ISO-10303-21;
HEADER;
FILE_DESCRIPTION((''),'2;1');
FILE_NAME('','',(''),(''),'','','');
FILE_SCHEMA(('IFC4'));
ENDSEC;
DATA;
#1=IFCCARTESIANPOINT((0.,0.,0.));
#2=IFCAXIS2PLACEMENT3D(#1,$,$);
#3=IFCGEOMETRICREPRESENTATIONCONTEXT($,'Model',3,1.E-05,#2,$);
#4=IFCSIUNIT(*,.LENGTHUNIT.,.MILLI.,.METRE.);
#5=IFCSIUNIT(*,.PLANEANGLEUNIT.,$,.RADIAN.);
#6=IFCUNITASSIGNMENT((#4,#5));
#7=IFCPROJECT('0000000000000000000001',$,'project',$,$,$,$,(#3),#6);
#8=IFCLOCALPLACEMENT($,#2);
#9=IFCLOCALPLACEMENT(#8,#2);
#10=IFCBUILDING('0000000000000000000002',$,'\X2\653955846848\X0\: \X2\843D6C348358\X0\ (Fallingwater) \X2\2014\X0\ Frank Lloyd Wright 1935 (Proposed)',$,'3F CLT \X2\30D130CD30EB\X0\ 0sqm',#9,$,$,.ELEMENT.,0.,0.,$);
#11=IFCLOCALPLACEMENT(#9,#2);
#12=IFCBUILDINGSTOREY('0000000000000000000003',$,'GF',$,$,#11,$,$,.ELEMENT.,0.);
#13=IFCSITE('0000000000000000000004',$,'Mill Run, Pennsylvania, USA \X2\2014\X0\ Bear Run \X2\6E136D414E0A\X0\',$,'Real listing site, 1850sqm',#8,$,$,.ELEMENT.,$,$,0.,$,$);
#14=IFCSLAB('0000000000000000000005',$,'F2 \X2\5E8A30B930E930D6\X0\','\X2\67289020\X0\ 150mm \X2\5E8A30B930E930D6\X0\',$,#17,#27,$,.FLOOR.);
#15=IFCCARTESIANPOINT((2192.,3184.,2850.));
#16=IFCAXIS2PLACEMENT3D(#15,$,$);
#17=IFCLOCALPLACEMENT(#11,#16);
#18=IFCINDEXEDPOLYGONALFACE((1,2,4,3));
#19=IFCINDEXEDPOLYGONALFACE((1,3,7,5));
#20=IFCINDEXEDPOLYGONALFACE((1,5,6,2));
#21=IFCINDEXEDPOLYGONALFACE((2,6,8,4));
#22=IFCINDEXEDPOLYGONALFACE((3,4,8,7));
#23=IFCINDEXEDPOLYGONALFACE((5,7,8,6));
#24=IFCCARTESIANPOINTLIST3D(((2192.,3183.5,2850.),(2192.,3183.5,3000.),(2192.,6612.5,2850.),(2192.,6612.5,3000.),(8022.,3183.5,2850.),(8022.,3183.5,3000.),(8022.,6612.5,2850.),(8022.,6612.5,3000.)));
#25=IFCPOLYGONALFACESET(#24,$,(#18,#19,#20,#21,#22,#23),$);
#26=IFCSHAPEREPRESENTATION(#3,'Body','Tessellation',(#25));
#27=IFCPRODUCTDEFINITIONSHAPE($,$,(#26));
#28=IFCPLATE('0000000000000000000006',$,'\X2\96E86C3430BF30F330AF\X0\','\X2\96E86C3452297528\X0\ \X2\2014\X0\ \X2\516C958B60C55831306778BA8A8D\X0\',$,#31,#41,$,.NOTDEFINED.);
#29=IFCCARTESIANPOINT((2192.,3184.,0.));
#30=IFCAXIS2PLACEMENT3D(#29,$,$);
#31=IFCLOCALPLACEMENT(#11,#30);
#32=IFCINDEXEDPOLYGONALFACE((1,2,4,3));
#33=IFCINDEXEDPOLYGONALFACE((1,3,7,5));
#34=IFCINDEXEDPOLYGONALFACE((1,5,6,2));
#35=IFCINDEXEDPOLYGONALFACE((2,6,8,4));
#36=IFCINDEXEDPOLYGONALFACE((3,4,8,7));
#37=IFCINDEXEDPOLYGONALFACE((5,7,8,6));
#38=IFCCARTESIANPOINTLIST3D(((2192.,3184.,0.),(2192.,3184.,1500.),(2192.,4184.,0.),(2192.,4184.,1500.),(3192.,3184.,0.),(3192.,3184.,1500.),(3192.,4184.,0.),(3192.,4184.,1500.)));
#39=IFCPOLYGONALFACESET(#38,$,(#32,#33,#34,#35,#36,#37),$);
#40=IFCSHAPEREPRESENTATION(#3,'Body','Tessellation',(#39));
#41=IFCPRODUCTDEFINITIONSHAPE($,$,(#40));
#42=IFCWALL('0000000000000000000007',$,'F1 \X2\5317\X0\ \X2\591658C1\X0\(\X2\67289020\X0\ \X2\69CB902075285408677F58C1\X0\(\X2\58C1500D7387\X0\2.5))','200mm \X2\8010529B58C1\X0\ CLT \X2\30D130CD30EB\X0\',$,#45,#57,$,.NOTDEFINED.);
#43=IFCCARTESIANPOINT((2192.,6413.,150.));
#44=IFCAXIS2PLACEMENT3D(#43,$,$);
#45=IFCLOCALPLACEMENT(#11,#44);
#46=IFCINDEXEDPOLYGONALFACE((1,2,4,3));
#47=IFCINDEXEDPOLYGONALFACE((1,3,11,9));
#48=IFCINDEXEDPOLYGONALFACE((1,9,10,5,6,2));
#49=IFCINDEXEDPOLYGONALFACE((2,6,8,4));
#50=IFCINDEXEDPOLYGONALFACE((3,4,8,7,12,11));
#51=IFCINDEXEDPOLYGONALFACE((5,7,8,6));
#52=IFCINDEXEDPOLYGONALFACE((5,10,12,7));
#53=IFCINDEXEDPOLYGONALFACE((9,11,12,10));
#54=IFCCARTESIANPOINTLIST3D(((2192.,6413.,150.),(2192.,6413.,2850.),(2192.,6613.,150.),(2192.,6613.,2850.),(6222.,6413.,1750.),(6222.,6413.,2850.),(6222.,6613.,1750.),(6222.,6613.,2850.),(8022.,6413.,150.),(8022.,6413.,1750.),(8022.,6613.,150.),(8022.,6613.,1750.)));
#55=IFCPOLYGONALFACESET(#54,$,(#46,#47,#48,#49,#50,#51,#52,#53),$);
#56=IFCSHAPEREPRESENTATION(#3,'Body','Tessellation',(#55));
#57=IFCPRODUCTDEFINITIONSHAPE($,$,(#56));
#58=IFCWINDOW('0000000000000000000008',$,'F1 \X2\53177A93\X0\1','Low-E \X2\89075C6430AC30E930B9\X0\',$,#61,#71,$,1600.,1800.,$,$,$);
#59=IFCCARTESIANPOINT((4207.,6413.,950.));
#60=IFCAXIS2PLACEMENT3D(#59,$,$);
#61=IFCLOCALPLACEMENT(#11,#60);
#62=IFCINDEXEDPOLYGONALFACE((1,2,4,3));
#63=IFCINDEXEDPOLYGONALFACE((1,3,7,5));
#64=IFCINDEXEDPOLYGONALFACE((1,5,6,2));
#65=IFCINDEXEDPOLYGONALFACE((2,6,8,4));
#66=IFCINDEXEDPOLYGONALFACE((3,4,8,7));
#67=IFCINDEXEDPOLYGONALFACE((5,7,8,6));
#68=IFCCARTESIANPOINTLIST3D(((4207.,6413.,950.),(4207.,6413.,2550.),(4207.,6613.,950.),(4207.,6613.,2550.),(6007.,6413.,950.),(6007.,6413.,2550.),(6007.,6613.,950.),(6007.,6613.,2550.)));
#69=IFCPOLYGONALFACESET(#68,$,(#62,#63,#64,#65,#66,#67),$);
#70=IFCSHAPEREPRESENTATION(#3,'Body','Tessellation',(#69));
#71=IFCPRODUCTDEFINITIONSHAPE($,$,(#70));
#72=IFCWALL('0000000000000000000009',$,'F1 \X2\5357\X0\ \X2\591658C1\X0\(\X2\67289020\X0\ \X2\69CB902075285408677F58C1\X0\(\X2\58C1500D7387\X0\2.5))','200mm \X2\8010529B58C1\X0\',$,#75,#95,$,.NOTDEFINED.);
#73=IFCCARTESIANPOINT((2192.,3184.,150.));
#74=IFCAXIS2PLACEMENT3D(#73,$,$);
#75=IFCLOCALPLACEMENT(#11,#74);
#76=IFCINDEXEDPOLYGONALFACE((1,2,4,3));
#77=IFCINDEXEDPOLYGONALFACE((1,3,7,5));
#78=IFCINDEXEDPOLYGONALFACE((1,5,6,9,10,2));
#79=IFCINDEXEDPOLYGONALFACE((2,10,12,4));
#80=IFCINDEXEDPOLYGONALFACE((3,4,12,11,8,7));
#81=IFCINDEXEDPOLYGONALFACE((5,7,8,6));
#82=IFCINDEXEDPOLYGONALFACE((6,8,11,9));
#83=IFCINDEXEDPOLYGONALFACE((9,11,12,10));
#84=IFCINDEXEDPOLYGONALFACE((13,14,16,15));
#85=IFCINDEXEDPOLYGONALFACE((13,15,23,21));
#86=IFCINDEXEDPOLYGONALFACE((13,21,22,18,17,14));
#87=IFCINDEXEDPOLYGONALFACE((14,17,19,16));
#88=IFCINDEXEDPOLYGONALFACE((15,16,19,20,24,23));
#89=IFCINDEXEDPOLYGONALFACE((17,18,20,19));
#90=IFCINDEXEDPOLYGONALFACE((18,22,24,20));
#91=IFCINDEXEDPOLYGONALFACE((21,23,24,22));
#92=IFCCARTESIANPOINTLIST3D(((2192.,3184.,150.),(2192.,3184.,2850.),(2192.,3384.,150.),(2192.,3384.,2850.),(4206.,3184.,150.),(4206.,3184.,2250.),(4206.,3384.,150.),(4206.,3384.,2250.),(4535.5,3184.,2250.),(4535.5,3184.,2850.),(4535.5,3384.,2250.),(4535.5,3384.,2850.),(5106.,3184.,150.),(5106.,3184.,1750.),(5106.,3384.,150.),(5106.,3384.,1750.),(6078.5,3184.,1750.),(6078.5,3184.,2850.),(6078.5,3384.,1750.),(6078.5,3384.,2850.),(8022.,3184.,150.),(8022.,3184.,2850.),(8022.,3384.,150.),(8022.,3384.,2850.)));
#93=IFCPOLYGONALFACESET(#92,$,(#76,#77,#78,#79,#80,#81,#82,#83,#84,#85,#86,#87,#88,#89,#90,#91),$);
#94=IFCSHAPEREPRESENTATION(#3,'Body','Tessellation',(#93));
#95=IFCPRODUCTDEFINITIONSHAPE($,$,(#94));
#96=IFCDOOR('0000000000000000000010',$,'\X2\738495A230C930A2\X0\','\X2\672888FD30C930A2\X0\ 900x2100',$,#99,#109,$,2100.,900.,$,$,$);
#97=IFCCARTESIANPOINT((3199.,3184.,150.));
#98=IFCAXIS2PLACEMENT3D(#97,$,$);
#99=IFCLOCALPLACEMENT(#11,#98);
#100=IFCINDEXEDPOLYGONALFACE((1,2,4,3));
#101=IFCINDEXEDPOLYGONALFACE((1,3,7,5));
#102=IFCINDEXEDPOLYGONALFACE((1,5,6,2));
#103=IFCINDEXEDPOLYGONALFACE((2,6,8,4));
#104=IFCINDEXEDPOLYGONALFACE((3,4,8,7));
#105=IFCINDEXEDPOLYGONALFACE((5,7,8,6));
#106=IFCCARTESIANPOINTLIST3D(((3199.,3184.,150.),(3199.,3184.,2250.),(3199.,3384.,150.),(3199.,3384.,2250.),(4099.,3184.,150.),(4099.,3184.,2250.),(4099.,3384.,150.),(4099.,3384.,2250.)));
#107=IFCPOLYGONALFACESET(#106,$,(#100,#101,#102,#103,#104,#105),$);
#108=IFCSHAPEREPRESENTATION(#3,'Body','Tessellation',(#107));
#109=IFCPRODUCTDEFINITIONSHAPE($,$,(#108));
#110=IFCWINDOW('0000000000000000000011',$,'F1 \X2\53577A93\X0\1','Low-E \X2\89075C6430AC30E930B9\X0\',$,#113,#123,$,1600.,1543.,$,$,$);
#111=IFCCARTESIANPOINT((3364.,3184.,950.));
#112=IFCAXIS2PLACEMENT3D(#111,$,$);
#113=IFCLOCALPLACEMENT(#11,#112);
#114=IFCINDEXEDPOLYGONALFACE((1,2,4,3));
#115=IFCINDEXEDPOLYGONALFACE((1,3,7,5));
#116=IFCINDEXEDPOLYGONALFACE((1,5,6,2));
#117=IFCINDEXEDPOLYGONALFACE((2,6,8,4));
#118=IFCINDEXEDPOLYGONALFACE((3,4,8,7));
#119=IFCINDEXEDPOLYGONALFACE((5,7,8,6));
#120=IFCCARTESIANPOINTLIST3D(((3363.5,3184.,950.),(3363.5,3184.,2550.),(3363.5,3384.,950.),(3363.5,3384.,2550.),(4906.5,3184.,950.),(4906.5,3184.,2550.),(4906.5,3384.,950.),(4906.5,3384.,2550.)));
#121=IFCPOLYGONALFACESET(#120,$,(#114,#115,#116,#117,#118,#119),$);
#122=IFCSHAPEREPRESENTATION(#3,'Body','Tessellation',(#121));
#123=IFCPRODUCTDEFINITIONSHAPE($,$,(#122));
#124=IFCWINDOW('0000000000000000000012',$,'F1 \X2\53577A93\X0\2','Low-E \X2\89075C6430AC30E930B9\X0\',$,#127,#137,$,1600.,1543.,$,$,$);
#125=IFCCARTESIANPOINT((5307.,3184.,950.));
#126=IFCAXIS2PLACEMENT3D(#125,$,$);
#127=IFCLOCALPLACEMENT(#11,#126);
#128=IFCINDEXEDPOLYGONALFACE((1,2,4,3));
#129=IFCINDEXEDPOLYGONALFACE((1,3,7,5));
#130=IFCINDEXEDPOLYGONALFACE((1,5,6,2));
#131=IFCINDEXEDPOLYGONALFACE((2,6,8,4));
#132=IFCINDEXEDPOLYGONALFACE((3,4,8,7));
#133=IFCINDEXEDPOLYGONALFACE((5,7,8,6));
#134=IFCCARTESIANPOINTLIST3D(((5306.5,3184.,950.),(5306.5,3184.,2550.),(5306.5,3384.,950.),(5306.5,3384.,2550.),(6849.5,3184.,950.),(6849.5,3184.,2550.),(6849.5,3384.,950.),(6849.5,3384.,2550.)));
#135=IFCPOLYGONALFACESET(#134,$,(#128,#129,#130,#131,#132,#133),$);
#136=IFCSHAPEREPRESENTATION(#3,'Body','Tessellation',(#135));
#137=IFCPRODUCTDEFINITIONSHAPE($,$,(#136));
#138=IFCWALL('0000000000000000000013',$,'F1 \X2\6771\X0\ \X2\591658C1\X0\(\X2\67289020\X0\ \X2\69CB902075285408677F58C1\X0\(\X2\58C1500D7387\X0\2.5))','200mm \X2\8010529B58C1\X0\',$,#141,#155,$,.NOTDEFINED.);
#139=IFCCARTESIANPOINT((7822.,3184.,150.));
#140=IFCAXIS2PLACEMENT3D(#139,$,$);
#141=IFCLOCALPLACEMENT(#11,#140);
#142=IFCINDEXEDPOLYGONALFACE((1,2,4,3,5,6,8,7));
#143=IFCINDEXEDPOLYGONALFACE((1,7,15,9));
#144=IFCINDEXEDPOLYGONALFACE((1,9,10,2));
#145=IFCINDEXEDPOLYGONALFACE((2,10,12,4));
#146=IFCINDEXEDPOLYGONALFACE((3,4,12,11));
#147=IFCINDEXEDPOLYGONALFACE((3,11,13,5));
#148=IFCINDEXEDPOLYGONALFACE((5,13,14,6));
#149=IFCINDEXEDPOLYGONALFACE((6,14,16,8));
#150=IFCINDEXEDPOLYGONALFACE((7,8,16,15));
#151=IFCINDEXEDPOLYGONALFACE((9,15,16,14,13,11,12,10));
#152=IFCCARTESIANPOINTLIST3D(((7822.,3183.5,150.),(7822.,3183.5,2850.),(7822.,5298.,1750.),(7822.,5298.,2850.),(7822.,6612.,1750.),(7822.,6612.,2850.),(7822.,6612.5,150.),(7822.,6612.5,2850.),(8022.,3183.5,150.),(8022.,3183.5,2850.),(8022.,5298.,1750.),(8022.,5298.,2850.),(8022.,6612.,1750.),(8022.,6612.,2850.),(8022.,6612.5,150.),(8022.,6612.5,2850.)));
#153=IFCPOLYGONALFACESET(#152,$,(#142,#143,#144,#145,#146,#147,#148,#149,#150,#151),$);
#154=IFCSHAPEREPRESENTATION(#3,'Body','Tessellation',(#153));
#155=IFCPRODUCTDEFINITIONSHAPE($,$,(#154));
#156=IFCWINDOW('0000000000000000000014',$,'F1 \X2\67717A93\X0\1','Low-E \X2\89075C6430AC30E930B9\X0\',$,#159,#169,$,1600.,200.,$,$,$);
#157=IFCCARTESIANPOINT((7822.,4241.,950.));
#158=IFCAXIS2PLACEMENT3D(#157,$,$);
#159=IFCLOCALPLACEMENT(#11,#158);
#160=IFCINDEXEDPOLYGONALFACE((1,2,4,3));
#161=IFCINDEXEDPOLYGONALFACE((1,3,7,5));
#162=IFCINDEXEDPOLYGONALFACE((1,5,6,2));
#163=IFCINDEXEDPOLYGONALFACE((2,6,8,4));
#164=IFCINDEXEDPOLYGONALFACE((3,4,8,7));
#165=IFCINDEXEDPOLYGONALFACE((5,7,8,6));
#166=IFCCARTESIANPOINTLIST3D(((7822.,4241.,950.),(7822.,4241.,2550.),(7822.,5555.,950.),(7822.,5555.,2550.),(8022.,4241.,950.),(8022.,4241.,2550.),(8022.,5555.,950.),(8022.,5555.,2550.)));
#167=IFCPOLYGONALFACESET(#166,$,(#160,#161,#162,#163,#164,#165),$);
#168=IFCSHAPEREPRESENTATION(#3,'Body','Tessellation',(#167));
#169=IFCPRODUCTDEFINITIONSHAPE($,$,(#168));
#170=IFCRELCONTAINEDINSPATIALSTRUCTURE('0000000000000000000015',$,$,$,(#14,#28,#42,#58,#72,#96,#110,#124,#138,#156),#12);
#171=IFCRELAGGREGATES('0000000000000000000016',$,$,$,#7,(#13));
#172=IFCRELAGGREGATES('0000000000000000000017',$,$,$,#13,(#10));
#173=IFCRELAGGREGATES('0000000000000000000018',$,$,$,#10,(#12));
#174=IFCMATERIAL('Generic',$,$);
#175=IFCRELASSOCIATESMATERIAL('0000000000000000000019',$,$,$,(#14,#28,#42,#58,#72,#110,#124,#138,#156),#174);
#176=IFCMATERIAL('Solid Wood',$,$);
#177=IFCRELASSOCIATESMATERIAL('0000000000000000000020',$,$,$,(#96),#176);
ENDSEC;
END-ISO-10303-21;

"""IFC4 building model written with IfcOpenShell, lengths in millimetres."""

from ifc_helpers import new_model, si_unit, frame, frame_2d, origin, place, context, project, spatial, rectangle, extrude, material, element, fill, save


model = new_model("IFC4")

# Units and contexts
model_context = context("Model", 3, precision=1e-05, world=origin())
ifc_project = project(units=[si_unit("LENGTHUNIT", "METRE", prefix="MILLI"), si_unit("PLANEANGLEUNIT", "RADIAN")], contexts=[model_context])

# Site, building, storey
site_placement = place(None, origin())
site = spatial("IfcSite", under=ifc_project, at=site_placement, Name="Mill Run, Pennsylvania, USA — Bear Run 渓流上", ObjectType="Real listing site, 1850sqm", CompositionType="ELEMENT", RefElevation=0.0)
building_placement = place(site_placement, origin())
building = spatial("IfcBuilding", under=site, at=building_placement, Name="改善案: 落水荘 (Fallingwater) — Frank Lloyd Wright 1935 (Proposed)", ObjectType="3F CLT パネル 0sqm", CompositionType="ELEMENT", ElevationOfRefHeight=0.0, ElevationOfTerrain=0.0)
storey_placement = place(building_placement, origin())
storey = spatial("IfcBuildingStorey", under=building, at=storey_placement, Name="GF", CompositionType="ELEMENT", Elevation=0.0)

# Slab
ifc_material_1 = material(Name="Generic")
slab_1_placement = place(storey_placement, frame((2192.0, 3184.0, 2850.0)))
element("IfcSlab", 1, at=slab_1_placement, inside=storey, material=ifc_material_1, Name="F2 床スラブ", Description="木造 150mm 床スラブ", PredefinedType="FLOOR", context=model_context, shape_type="SweptSolid", body=[
    extrude(rectangle(XDim=5830.0, YDim=3429.0, at=frame_2d((2915.0, 1714.0))), frame((2192.0, 3184.0, 2850.0)), (0.0, 0.0, 1.0), 150.0),
])

# Plate
plate_placement = place(storey_placement, frame((2192.0, 3184.0, 0.0)))
element("IfcPlate", 2, at=plate_placement, inside=storey, material=ifc_material_1, Name="雨水タンク", Description="雨水利用 — 公開情報で確認", PredefinedType="NOTDEFINED", context=model_context, shape_type="SweptSolid", body=[
    extrude(rectangle(XDim=1000.0, YDim=1000.0, at=frame_2d((500.0, 500.0))), frame((2192.0, 3184.0, 0.0)), (0.0, 0.0, 1.0), 1500.0),
])

# Wall, opening, window
wall_1_placement = place(storey_placement, frame((2192.0, 6413.0, 150.0)))
wall_1 = element("IfcWall", 3, at=wall_1_placement, inside=storey, material=ifc_material_1, Name="F1 北 外壁(木造 構造用合板壁(壁倍率2.5))", Description="200mm 耐力壁 CLT パネル", PredefinedType="NOTDEFINED", context=model_context, shape_type="SweptSolid", body=[
    extrude(rectangle(XDim=5830.0, YDim=200.0, at=frame_2d((2915.0, 100.0))), frame((2192.0, 6413.0, 150.0)), (0.0, 0.0, 1.0), 2700.0),
])
opening_1_placement = place(storey_placement, frame((4207.0, 6413.0, 950.0)))
opening_1 = element("IfcOpeningElement", 4, at=opening_1_placement, cuts=wall_1, PredefinedType="NOTDEFINED", context=model_context, shape_type="SweptSolid", body=[
    extrude(rectangle(XDim=1800.0, YDim=200.0, at=frame_2d((900.0, 100.0))), frame((4207.0, 6413.0, 950.0)), (0.0, 0.0, 1.0), 1600.0),
])
window_1_placement = place(storey_placement, frame((4207.0, 6413.0, 950.0)))
window_1 = element("IfcWindow", 5, at=window_1_placement, inside=storey, material=ifc_material_1, Name="F1 北窓1", Description="Low-E 複層ガラス", OverallHeight=1600.0, OverallWidth=1800.0, context=model_context, shape_type="SweptSolid", body=[
    extrude(rectangle(XDim=1800.0, YDim=200.0, at=frame_2d((900.0, 100.0))), frame((4207.0, 6413.0, 950.0)), (0.0, 0.0, 1.0), 1600.0),
])
fill(opening_1, window_1)

# Wall, openings, door, windows
wall_2_placement = place(storey_placement, frame((2192.0, 3184.0, 150.0)))
wall_2 = element("IfcWall", 6, at=wall_2_placement, inside=storey, material=ifc_material_1, Name="F1 南 外壁(木造 構造用合板壁(壁倍率2.5))", Description="200mm 耐力壁", PredefinedType="NOTDEFINED", context=model_context, shape_type="SweptSolid", body=[
    extrude(rectangle(XDim=5830.0, YDim=200.0, at=frame_2d((2915.0, 100.0))), frame((2192.0, 3184.0, 150.0)), (0.0, 0.0, 1.0), 2700.0),
])
opening_2_placement = place(storey_placement, frame((3199.0, 3184.0, 150.0)))
opening_2 = element("IfcOpeningElement", 7, at=opening_2_placement, cuts=wall_2, PredefinedType="NOTDEFINED", context=model_context, shape_type="SweptSolid", body=[
    extrude(rectangle(XDim=900.0, YDim=200.0, at=frame_2d((450.0, 100.0))), frame((3199.0, 3184.0, 150.0)), (0.0, 0.0, 1.0), 2100.0),
])
opening_3_placement = place(storey_placement, frame((3364.0, 3184.0, 950.0)))
opening_3 = element("IfcOpeningElement", 8, at=opening_3_placement, cuts=wall_2, PredefinedType="NOTDEFINED", context=model_context, shape_type="SweptSolid", body=[
    extrude(rectangle(XDim=1543.0, YDim=200.0, at=frame_2d((771.0, 100.0))), frame((3364.0, 3184.0, 950.0)), (0.0, 0.0, 1.0), 1600.0),
])
opening_4_placement = place(storey_placement, frame((5307.0, 3184.0, 950.0)))
opening_4 = element("IfcOpeningElement", 9, at=opening_4_placement, cuts=wall_2, PredefinedType="NOTDEFINED", context=model_context, shape_type="SweptSolid", body=[
    extrude(rectangle(XDim=1543.0, YDim=200.0, at=frame_2d((771.0, 100.0))), frame((5307.0, 3184.0, 950.0)), (0.0, 0.0, 1.0), 1600.0),
])
ifc_material_2 = material(Name="Solid Wood")
door_placement = place(storey_placement, frame((3199.0, 3184.0, 150.0)))
door = element("IfcDoor", 10, at=door_placement, inside=storey, material=ifc_material_2, Name="玄関ドア", Description="木製ドア 900x2100", OverallHeight=2100.0, OverallWidth=900.0, context=model_context, shape_type="SweptSolid", body=[
    extrude(rectangle(XDim=900.0, YDim=200.0, at=frame_2d((450.0, 100.0))), frame((3199.0, 3184.0, 150.0)), (0.0, 0.0, 1.0), 2100.0),
])
fill(opening_2, door)
window_2_placement = place(storey_placement, frame((3364.0, 3184.0, 950.0)))
window_2 = element("IfcWindow", 11, at=window_2_placement, inside=storey, material=ifc_material_1, Name="F1 南窓1", Description="Low-E 複層ガラス", OverallHeight=1600.0, OverallWidth=1543.0, context=model_context, shape_type="SweptSolid", body=[
    extrude(rectangle(XDim=1543.0, YDim=200.0, at=frame_2d((771.0, 100.0))), frame((3364.0, 3184.0, 950.0)), (0.0, 0.0, 1.0), 1600.0),
])
fill(opening_3, window_2)
window_3_placement = place(storey_placement, frame((5307.0, 3184.0, 950.0)))
window_3 = element("IfcWindow", 12, at=window_3_placement, inside=storey, material=ifc_material_1, Name="F1 南窓2", Description="Low-E 複層ガラス", OverallHeight=1600.0, OverallWidth=1543.0, context=model_context, shape_type="SweptSolid", body=[
    extrude(rectangle(XDim=1543.0, YDim=200.0, at=frame_2d((771.0, 100.0))), frame((5307.0, 3184.0, 950.0)), (0.0, 0.0, 1.0), 1600.0),
])
fill(opening_4, window_3)

# Wall, opening, window
wall_3_placement = place(storey_placement, frame((7822.0, 3184.0, 150.0)))
wall_3 = element("IfcWall", 13, at=wall_3_placement, inside=storey, material=ifc_material_1, Name="F1 東 外壁(木造 構造用合板壁(壁倍率2.5))", Description="200mm 耐力壁", PredefinedType="NOTDEFINED", context=model_context, shape_type="SweptSolid", body=[
    extrude(rectangle(XDim=200.0, YDim=3429.0, at=frame_2d((100.0, 1714.0))), frame((7822.0, 3184.0, 150.0)), (0.0, 0.0, 1.0), 2700.0),
])
opening_5_placement = place(storey_placement, frame((7822.0, 4241.0, 950.0)))
opening_5 = element("IfcOpeningElement", 14, at=opening_5_placement, cuts=wall_3, PredefinedType="NOTDEFINED", context=model_context, shape_type="SweptSolid", body=[
    extrude(rectangle(XDim=200.0, YDim=1314.0, at=frame_2d((100.0, 657.0))), frame((7822.0, 4241.0, 950.0)), (0.0, 0.0, 1.0), 1600.0),
])
window_4_placement = place(storey_placement, frame((7822.0, 4241.0, 950.0)))
window_4 = element("IfcWindow", 15, at=window_4_placement, inside=storey, material=ifc_material_1, Name="F1 東窓1", Description="Low-E 複層ガラス", OverallHeight=1600.0, OverallWidth=200.0, context=model_context, shape_type="SweptSolid", body=[
    extrude(rectangle(XDim=200.0, YDim=1314.0, at=frame_2d((100.0, 657.0))), frame((7822.0, 4241.0, 950.0)), (0.0, 0.0, 1.0), 1600.0),
])
fill(opening_5, window_4)

save(model, "model.ifc")
